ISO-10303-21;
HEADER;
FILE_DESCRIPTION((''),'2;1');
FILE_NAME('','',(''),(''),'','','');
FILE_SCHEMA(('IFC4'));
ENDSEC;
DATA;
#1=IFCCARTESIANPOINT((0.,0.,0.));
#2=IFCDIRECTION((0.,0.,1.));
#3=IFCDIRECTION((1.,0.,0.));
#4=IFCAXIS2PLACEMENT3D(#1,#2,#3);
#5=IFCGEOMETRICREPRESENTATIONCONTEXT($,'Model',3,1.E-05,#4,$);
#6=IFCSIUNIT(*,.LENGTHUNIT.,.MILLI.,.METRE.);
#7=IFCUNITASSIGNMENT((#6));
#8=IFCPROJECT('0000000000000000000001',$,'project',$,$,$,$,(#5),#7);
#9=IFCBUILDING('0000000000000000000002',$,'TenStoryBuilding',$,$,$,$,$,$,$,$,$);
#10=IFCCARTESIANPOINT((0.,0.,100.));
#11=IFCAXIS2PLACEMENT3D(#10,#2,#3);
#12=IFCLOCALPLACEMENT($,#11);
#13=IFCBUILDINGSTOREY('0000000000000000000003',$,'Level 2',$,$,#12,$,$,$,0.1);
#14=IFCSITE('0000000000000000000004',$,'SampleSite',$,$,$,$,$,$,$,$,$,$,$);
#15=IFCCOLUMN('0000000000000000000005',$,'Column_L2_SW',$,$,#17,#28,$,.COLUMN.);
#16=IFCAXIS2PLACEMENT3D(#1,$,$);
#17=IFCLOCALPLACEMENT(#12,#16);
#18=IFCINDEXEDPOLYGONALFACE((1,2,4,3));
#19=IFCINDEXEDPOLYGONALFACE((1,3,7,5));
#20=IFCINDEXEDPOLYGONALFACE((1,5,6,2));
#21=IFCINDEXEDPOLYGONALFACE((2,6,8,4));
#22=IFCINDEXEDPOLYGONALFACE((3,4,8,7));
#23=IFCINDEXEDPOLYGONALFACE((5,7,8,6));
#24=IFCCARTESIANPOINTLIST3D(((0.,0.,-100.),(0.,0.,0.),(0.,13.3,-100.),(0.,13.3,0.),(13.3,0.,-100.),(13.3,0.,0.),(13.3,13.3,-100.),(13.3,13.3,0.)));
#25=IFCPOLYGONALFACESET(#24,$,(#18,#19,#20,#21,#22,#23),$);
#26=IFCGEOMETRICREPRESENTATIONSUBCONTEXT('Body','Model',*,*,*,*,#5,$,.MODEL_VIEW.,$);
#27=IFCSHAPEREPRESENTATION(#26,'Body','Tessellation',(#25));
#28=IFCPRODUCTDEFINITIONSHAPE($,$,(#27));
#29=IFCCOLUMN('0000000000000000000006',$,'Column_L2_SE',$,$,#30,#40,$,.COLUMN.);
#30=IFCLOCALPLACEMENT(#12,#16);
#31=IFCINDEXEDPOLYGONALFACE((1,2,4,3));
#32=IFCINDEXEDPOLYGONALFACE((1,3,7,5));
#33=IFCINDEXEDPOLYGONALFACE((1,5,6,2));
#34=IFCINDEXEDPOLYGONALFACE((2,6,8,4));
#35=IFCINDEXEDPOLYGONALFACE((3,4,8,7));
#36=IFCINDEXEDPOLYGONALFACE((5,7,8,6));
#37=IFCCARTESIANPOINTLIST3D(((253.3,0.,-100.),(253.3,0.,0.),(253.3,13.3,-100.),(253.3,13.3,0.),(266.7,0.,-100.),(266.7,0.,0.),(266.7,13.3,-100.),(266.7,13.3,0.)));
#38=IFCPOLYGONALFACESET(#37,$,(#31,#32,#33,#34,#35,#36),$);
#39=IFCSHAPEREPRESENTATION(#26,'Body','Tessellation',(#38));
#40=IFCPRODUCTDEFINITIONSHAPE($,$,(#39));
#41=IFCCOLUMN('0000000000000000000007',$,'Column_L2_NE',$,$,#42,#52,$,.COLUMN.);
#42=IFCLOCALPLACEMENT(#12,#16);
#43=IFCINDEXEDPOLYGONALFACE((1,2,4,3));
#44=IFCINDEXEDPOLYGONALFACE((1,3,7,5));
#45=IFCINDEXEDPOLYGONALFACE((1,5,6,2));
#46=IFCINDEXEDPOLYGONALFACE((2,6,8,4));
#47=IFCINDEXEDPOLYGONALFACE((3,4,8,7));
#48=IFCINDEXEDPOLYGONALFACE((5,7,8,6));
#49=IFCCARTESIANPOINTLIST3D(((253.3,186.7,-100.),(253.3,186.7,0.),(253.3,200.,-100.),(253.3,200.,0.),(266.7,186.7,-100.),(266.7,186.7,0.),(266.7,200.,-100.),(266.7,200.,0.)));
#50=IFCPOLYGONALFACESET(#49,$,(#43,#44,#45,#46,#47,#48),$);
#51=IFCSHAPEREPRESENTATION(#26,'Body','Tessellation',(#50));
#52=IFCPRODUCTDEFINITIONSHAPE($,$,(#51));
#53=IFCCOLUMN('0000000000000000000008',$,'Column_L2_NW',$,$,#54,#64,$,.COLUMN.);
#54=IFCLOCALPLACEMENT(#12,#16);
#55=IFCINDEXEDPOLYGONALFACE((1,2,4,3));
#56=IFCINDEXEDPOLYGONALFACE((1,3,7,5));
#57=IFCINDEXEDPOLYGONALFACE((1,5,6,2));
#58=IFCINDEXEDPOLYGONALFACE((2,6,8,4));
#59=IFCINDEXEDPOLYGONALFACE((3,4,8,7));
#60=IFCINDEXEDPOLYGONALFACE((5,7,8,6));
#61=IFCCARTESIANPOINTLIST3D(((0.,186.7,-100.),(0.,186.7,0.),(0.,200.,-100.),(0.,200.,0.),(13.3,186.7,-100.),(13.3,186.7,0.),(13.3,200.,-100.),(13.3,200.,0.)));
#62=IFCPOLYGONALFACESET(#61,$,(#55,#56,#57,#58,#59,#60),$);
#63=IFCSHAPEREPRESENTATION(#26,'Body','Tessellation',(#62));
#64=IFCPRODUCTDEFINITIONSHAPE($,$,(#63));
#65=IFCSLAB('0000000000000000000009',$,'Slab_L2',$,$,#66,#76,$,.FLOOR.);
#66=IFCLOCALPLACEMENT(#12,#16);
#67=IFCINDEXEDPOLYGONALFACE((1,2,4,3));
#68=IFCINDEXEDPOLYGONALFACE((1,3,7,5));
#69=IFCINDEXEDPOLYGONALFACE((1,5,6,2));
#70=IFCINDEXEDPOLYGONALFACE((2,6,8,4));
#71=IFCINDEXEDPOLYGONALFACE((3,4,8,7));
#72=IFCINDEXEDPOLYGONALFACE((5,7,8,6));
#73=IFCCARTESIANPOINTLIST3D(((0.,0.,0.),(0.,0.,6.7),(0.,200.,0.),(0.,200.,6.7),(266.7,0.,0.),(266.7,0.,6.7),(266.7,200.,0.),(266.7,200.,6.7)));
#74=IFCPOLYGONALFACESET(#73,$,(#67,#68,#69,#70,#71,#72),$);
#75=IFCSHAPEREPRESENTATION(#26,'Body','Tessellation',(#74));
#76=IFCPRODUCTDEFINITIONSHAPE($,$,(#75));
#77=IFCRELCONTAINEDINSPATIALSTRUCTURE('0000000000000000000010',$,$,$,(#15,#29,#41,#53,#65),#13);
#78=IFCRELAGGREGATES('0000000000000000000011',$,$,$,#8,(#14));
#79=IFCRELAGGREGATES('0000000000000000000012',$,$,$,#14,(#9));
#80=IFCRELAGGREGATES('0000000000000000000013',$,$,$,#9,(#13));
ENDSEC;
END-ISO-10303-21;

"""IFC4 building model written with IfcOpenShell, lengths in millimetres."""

from ifc_helpers import new_model, si_unit, frame, origin_with_axes, origin_2d, place, context, subcontext, project, spatial, indexed_curve, rectangle, outline, extrude, element, save


model = new_model("IFC4")

# Units and contexts
model_context = context("Model", 3, precision=1e-05, world=origin_with_axes())
body_context = subcontext(model_context, "Body", "Model", "MODEL_VIEW")
ifc_project = project(units=[si_unit("LENGTHUNIT", "METRE", prefix="MILLI")], contexts=[model_context])

# Site, building, storey
site = spatial("IfcSite", under=ifc_project, Name="SampleSite")
building = spatial("IfcBuilding", under=site, Name="TenStoryBuilding")
storey_placement = place(None, frame((0.0, 0.0, 100.0), z_axis=(0.0, 0.0, 1.0), x_axis=(1.0, 0.0, 0.0)))
storey = spatial("IfcBuildingStorey", under=building, at=storey_placement, Name="Level 2", Elevation=0.1)

# Columns
for number, where, z_axis, x_axis, name in (
    (1, (6.7, 6.7, -100.0), (0.0, 0.0, 1.0), (1.0, 0.0, 0.0), "Column_L2_SW"),
    (2, (260.0, 6.7, -100.0), (0.0, 0.0, 1.0), (1.0, 0.0, 0.0), "Column_L2_SE"),
    (3, (260.0, 193.3, -100.0), (0.0, 0.0, 1.0), (1.0, 0.0, 0.0), "Column_L2_NE"),
    (4, (6.7, 193.3, -100.0), (0.0, 0.0, 1.0), (1.0, 0.0, 0.0), "Column_L2_NW"),
):
    element("IfcColumn", number, at=place(storey_placement, frame(where, z_axis=z_axis, x_axis=x_axis)), inside=storey, Name=name, PredefinedType="COLUMN", context=body_context, shape_type="SweptSolid", body=[
        extrude(rectangle(XDim=13.3, YDim=13.3, at=origin_2d()), origin_with_axes(), (0.0, 0.0, 1.0), 100.0),
    ])

# Slab
slab_placement = place(storey_placement, origin_with_axes())
element("IfcSlab", 5, at=slab_placement, inside=storey, Name="Slab_L2", PredefinedType="FLOOR", context=body_context, shape_type="SweptSolid", body=[
    extrude(outline(indexed_curve([(0.0, 0.0), (266.7, 0.0), (266.7, 200.0), (0.0, 200.0), (0.0, 0.0)])), None, (0.0, 0.0, 1.0), 6.7),
])

save(model, "model.ifc")
